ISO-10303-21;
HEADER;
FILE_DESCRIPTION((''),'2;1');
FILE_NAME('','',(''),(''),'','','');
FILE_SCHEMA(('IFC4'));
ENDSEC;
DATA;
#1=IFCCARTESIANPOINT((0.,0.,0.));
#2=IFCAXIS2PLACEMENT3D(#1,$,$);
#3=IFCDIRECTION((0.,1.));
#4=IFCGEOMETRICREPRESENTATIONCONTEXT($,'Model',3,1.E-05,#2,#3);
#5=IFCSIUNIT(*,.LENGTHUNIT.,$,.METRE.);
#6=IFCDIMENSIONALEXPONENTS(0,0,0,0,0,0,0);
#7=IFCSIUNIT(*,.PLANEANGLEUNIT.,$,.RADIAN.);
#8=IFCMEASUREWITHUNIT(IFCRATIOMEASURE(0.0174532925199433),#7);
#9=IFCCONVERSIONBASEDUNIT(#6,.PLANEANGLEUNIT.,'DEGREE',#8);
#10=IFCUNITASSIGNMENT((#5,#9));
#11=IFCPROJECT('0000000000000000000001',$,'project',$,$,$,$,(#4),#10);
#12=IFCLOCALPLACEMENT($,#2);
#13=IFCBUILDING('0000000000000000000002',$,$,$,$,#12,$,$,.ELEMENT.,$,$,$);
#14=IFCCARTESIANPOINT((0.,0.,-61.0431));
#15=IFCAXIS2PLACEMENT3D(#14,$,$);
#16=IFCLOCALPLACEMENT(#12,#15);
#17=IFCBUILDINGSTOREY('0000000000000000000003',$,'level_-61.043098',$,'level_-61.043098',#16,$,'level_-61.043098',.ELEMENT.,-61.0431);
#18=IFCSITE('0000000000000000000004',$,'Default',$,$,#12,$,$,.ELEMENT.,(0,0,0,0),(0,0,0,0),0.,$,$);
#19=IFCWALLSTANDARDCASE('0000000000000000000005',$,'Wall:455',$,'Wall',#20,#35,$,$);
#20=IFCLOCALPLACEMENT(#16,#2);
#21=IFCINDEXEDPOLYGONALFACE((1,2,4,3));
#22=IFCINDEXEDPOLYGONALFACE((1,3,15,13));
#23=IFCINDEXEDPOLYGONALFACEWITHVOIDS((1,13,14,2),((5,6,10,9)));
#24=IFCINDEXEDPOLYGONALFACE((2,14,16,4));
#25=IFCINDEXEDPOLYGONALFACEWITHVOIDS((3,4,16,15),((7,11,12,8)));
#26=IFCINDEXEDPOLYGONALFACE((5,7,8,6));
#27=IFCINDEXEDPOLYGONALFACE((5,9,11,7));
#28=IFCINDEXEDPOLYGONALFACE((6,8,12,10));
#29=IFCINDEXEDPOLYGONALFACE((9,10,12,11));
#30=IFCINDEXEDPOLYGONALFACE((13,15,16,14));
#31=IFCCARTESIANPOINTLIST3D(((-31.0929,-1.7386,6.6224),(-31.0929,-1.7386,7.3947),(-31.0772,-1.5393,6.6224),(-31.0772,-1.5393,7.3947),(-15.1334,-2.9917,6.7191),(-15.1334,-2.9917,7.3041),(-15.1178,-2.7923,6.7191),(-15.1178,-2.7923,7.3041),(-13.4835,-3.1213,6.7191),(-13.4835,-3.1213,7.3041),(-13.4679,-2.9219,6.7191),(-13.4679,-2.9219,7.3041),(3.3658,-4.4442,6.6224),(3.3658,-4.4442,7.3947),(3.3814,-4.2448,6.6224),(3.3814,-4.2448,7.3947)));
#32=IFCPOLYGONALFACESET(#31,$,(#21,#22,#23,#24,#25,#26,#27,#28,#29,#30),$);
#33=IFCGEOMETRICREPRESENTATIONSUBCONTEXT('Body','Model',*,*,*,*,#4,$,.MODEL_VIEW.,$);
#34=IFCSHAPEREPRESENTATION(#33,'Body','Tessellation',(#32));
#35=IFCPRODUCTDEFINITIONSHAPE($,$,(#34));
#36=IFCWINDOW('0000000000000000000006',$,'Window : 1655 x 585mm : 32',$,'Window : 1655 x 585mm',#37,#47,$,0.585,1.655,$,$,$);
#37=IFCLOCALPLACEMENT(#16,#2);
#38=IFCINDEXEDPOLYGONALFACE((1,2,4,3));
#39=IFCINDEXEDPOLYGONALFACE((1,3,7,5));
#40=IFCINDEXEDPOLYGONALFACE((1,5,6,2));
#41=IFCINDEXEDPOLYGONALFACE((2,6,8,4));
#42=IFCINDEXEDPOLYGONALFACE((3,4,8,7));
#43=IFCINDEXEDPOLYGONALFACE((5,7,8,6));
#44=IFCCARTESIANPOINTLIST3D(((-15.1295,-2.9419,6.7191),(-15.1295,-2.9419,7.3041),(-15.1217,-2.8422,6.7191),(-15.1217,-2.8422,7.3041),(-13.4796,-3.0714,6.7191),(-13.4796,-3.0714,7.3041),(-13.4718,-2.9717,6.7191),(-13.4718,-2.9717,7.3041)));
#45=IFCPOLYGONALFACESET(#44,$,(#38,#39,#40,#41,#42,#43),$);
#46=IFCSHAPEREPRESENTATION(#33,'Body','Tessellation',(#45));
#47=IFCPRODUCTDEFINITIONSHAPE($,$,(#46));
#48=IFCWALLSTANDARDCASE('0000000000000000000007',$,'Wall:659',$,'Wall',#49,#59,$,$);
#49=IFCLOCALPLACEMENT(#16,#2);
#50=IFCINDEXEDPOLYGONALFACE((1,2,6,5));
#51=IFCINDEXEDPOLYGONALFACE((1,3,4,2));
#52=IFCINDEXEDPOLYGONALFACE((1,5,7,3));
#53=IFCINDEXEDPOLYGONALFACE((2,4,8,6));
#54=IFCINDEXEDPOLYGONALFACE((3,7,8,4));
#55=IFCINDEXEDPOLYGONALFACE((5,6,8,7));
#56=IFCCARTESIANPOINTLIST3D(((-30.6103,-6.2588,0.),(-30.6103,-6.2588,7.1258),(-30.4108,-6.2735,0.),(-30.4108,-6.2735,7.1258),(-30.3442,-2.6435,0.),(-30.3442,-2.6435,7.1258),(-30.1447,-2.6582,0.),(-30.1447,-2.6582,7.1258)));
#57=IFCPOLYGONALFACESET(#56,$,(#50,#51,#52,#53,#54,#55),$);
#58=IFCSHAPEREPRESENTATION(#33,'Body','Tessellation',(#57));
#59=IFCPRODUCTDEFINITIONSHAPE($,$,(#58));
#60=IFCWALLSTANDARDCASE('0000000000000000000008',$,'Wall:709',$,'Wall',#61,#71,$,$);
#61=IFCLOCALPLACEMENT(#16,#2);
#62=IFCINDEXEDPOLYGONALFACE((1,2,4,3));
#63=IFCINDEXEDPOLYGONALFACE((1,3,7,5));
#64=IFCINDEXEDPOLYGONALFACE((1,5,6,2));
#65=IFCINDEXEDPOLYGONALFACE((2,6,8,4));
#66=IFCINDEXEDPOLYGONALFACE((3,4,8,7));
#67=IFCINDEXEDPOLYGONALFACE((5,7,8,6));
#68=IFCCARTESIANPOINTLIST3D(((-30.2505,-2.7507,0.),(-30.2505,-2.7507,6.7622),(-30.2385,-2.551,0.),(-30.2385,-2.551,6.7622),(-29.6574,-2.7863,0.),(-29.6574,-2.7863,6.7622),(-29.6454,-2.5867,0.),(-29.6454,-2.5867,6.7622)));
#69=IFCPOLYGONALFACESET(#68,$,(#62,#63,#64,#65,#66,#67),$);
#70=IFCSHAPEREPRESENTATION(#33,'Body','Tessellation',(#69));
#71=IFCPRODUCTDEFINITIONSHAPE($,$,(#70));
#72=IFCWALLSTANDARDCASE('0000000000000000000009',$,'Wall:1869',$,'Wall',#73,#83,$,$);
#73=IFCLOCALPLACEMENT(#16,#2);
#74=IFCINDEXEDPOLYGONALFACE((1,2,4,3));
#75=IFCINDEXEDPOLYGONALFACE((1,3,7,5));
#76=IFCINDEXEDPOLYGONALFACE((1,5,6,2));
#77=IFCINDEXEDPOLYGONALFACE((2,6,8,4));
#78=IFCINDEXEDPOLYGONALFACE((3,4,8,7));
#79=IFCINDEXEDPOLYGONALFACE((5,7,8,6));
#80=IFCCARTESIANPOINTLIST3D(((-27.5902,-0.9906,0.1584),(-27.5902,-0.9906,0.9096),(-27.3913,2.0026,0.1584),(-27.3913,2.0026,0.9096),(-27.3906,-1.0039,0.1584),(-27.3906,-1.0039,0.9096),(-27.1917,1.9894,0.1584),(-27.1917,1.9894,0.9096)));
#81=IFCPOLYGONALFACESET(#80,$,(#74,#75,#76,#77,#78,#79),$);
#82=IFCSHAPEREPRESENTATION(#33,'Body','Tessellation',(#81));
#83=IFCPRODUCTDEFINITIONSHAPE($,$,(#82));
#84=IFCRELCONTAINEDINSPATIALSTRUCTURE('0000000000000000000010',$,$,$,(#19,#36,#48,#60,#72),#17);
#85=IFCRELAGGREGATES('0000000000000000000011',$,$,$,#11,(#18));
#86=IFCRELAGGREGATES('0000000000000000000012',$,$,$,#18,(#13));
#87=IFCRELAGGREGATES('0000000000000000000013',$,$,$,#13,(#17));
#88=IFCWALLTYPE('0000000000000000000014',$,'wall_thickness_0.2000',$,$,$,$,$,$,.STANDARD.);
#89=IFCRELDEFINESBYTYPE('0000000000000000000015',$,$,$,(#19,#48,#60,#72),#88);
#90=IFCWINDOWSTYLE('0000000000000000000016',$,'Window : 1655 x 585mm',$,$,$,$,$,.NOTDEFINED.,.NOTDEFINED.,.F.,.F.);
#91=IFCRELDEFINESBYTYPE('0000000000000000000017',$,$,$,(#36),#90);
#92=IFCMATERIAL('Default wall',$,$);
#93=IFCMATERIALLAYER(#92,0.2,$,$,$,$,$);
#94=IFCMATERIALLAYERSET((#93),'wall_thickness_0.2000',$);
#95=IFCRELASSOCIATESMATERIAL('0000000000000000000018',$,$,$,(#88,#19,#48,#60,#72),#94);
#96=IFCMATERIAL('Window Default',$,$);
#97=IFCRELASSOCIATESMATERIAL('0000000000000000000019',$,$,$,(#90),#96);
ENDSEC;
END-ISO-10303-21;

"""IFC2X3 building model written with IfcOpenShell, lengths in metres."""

from ifc_helpers import new_model, entity, si_unit, converted_unit, direction, frame, frame_2d, origin, origin_2d_with_axis, place, context, subcontext, project, spatial, polyline, rectangle, outline, extrude, source, transform, mapped, material, layer, layer_set, layer_usage, type_object, type_shapes, element, fill, save


model = new_model("IFC2X3")

# Units and contexts
model_context = context("Model", 3, precision=1e-05, world=origin(), true_north=direction((0.0, 1.0)))
body_context = subcontext(model_context, "Body", "Model", "MODEL_VIEW")
ifc_project = project(units=[si_unit("LENGTHUNIT", "METRE"), converted_unit("PLANEANGLEUNIT", "DEGREE", entity("IfcRatioMeasure", 0.0174532925199433), si_unit("PLANEANGLEUNIT", "RADIAN"), dimensions=[0, 0, 0, 0, 0, 0, 0])], contexts=[model_context])

# Site, building, storey
placement_1 = place(None, origin())
site = spatial("IfcSite", under=ifc_project, at=placement_1, Name="Default", CompositionType="ELEMENT", RefLatitude=(0, 0, 0, 0), RefLongitude=(0, 0, 0, 0), RefElevation=0.0)
building = spatial("IfcBuilding", under=site, at=placement_1, CompositionType="ELEMENT")
storey_placement = place(placement_1, frame((0.0, 0.0, -61.0431)))
storey = spatial("IfcBuildingStorey", under=building, at=storey_placement, Name="level_-61.043098", ObjectType="level_-61.043098", LongName="level_-61.043098", CompositionType="ELEMENT", Elevation=-61.0431)

# Wall, opening, window
ifc_material_1 = material(Name="Default wall")
ifc_layer = layer(ifc_material_1, 0.2)
ifc_layer_set = layer_set([ifc_layer], Name="wall_thickness_0.2000")
ifc_layer_usage = layer_usage(ifc_layer_set, "AXIS2", "POSITIVE", -0.1)
wall_type = type_object("IfcWallType", Name="wall_thickness_0.2000", PredefinedType="STANDARD", material=ifc_layer_set)
placement_2 = place(placement_1, frame((0.0, 0.0, -54.4207)))
wall_1_placement = place(placement_2, frame((-31.085, -1.6389, 0.0), z_axis=(0.0, 0.0, 1.0), x_axis=(0.996932, -0.078275, 0.0)))
wall_1 = element("IfcWallStandardCase", 1, at=wall_1_placement, inside=storey, type_object=wall_type, material=ifc_layer_usage, Name="Wall:455", ObjectType="Wall", context=body_context, shape_type="SweptSolid", body=[
    extrude(outline(polyline([(34.5647, -0.1), (34.5647, 0.1), (0.0, 0.1), (0.0, -0.1), (34.5647, -0.1)])), origin(), (0.0, 0.0, 1.0), 0.7723),
])
opening_1_placement = place(wall_1_placement, frame((16.0085, -0.1, 0.0967)))
opening_1 = element("IfcOpeningElement", 2, at=opening_1_placement, cuts=wall_1, ObjectType="Opening", context=body_context, shape_type="SweptSolid", body=[
    extrude(rectangle(XDim=1.655, YDim=0.585, at=frame_2d((0.2925, 0.8275), x_axis=(0.0, 1.0))), frame((0.0, 0.0, 0.0), z_axis=(0.0, 1.0, 0.0), x_axis=(0.0, 0.0, 1.0)), (0.0, 0.0, 1.0), 0.2),
])
ifc_material_2 = material(Name="Window Default")
window_style_1 = type_object("IfcWindowStyle", Name="Window : 1655 x 585mm", ConstructionType="NOTDEFINED", OperationType="NOTDEFINED", ParameterTakesPrecedence=False, Sizeable=False, material=ifc_material_2)
shared_shape_1 = source(origin(), body_context, "Body", "SweptSolid", [
    extrude(rectangle(XDim=0.1, YDim=1.655, at=origin_2d_with_axis()), frame((0.8275, 0.1, 0.0), z_axis=(0.0, 0.0, 1.0), x_axis=(0.0, 1.0, 0.0)), (0.0, 0.0, 1.0), 0.585),
])
type_shapes(window_style_1, [shared_shape_1])
window_1_placement = place(opening_1_placement, origin())
window_1 = element("IfcWindow", 3, at=window_1_placement, inside=storey, type_object=window_style_1, Name="Window : 1655 x 585mm : 32", ObjectType="Window : 1655 x 585mm", OverallHeight=0.585, OverallWidth=1.655, context=body_context, shape_type="MappedRepresentation", body=[
    mapped(shared_shape_1, transform((0.0, 0.0, 0.0), scale=1.0)),
])
fill(opening_1, window_1)

# Walls
wall_2_placement = place(storey_placement, frame((-30.2445, -2.6508, 0.0), z_axis=(0.0, 0.0, 1.0), x_axis=(-0.073408, -0.997302, 0.0)))
element("IfcWallStandardCase", 4, at=wall_2_placement, inside=storey, type_object=wall_type, material=ifc_layer_usage, Name="Wall:659", ObjectType="Wall", context=body_context, shape_type="SweptSolid", body=[
    extrude(outline(polyline([(3.6251, -0.1), (3.6251, 0.1), (0.0, 0.1), (0.0, -0.1), (3.6251, -0.1)])), origin(), (0.0, 0.0, 1.0), 7.1258),
])
wall_3_placement = place(storey_placement, frame((-29.6514, -2.6865, 0.0), z_axis=(0.0, 0.0, 1.0), x_axis=(-0.998199, 0.059992, 0.0)))
element("IfcWallStandardCase", 5, at=wall_3_placement, inside=storey, type_object=wall_type, material=ifc_layer_usage, Name="Wall:709", ObjectType="Wall", context=body_context, shape_type="SweptSolid", body=[
    extrude(outline(polyline([(0.5942, -0.1), (0.5942, 0.1), (0.0, 0.1), (0.0, -0.1), (0.5942, -0.1)])), origin(), (0.0, 0.0, 1.0), 6.7622),
])

# Wall
placement_3 = place(placement_1, frame((0.0, 0.0, -60.8847)))
wall_4_placement = place(placement_3, frame((-27.4904, -0.9972, 0.0), z_axis=(0.0, 0.0, 1.0), x_axis=(0.066302, 0.9978, 0.0)))
element("IfcWallStandardCase", 6, at=wall_4_placement, inside=storey, type_object=wall_type, material=ifc_layer_usage, Name="Wall:1869", ObjectType="Wall", context=body_context, shape_type="SweptSolid", body=[
    extrude(outline(polyline([(2.9998, -0.1), (2.9998, 0.1), (0.0, 0.1), (0.0, -0.1), (2.9998, -0.1)])), origin(), (0.0, 0.0, 1.0), 0.7512),
])

save(model, "model.ifc")
